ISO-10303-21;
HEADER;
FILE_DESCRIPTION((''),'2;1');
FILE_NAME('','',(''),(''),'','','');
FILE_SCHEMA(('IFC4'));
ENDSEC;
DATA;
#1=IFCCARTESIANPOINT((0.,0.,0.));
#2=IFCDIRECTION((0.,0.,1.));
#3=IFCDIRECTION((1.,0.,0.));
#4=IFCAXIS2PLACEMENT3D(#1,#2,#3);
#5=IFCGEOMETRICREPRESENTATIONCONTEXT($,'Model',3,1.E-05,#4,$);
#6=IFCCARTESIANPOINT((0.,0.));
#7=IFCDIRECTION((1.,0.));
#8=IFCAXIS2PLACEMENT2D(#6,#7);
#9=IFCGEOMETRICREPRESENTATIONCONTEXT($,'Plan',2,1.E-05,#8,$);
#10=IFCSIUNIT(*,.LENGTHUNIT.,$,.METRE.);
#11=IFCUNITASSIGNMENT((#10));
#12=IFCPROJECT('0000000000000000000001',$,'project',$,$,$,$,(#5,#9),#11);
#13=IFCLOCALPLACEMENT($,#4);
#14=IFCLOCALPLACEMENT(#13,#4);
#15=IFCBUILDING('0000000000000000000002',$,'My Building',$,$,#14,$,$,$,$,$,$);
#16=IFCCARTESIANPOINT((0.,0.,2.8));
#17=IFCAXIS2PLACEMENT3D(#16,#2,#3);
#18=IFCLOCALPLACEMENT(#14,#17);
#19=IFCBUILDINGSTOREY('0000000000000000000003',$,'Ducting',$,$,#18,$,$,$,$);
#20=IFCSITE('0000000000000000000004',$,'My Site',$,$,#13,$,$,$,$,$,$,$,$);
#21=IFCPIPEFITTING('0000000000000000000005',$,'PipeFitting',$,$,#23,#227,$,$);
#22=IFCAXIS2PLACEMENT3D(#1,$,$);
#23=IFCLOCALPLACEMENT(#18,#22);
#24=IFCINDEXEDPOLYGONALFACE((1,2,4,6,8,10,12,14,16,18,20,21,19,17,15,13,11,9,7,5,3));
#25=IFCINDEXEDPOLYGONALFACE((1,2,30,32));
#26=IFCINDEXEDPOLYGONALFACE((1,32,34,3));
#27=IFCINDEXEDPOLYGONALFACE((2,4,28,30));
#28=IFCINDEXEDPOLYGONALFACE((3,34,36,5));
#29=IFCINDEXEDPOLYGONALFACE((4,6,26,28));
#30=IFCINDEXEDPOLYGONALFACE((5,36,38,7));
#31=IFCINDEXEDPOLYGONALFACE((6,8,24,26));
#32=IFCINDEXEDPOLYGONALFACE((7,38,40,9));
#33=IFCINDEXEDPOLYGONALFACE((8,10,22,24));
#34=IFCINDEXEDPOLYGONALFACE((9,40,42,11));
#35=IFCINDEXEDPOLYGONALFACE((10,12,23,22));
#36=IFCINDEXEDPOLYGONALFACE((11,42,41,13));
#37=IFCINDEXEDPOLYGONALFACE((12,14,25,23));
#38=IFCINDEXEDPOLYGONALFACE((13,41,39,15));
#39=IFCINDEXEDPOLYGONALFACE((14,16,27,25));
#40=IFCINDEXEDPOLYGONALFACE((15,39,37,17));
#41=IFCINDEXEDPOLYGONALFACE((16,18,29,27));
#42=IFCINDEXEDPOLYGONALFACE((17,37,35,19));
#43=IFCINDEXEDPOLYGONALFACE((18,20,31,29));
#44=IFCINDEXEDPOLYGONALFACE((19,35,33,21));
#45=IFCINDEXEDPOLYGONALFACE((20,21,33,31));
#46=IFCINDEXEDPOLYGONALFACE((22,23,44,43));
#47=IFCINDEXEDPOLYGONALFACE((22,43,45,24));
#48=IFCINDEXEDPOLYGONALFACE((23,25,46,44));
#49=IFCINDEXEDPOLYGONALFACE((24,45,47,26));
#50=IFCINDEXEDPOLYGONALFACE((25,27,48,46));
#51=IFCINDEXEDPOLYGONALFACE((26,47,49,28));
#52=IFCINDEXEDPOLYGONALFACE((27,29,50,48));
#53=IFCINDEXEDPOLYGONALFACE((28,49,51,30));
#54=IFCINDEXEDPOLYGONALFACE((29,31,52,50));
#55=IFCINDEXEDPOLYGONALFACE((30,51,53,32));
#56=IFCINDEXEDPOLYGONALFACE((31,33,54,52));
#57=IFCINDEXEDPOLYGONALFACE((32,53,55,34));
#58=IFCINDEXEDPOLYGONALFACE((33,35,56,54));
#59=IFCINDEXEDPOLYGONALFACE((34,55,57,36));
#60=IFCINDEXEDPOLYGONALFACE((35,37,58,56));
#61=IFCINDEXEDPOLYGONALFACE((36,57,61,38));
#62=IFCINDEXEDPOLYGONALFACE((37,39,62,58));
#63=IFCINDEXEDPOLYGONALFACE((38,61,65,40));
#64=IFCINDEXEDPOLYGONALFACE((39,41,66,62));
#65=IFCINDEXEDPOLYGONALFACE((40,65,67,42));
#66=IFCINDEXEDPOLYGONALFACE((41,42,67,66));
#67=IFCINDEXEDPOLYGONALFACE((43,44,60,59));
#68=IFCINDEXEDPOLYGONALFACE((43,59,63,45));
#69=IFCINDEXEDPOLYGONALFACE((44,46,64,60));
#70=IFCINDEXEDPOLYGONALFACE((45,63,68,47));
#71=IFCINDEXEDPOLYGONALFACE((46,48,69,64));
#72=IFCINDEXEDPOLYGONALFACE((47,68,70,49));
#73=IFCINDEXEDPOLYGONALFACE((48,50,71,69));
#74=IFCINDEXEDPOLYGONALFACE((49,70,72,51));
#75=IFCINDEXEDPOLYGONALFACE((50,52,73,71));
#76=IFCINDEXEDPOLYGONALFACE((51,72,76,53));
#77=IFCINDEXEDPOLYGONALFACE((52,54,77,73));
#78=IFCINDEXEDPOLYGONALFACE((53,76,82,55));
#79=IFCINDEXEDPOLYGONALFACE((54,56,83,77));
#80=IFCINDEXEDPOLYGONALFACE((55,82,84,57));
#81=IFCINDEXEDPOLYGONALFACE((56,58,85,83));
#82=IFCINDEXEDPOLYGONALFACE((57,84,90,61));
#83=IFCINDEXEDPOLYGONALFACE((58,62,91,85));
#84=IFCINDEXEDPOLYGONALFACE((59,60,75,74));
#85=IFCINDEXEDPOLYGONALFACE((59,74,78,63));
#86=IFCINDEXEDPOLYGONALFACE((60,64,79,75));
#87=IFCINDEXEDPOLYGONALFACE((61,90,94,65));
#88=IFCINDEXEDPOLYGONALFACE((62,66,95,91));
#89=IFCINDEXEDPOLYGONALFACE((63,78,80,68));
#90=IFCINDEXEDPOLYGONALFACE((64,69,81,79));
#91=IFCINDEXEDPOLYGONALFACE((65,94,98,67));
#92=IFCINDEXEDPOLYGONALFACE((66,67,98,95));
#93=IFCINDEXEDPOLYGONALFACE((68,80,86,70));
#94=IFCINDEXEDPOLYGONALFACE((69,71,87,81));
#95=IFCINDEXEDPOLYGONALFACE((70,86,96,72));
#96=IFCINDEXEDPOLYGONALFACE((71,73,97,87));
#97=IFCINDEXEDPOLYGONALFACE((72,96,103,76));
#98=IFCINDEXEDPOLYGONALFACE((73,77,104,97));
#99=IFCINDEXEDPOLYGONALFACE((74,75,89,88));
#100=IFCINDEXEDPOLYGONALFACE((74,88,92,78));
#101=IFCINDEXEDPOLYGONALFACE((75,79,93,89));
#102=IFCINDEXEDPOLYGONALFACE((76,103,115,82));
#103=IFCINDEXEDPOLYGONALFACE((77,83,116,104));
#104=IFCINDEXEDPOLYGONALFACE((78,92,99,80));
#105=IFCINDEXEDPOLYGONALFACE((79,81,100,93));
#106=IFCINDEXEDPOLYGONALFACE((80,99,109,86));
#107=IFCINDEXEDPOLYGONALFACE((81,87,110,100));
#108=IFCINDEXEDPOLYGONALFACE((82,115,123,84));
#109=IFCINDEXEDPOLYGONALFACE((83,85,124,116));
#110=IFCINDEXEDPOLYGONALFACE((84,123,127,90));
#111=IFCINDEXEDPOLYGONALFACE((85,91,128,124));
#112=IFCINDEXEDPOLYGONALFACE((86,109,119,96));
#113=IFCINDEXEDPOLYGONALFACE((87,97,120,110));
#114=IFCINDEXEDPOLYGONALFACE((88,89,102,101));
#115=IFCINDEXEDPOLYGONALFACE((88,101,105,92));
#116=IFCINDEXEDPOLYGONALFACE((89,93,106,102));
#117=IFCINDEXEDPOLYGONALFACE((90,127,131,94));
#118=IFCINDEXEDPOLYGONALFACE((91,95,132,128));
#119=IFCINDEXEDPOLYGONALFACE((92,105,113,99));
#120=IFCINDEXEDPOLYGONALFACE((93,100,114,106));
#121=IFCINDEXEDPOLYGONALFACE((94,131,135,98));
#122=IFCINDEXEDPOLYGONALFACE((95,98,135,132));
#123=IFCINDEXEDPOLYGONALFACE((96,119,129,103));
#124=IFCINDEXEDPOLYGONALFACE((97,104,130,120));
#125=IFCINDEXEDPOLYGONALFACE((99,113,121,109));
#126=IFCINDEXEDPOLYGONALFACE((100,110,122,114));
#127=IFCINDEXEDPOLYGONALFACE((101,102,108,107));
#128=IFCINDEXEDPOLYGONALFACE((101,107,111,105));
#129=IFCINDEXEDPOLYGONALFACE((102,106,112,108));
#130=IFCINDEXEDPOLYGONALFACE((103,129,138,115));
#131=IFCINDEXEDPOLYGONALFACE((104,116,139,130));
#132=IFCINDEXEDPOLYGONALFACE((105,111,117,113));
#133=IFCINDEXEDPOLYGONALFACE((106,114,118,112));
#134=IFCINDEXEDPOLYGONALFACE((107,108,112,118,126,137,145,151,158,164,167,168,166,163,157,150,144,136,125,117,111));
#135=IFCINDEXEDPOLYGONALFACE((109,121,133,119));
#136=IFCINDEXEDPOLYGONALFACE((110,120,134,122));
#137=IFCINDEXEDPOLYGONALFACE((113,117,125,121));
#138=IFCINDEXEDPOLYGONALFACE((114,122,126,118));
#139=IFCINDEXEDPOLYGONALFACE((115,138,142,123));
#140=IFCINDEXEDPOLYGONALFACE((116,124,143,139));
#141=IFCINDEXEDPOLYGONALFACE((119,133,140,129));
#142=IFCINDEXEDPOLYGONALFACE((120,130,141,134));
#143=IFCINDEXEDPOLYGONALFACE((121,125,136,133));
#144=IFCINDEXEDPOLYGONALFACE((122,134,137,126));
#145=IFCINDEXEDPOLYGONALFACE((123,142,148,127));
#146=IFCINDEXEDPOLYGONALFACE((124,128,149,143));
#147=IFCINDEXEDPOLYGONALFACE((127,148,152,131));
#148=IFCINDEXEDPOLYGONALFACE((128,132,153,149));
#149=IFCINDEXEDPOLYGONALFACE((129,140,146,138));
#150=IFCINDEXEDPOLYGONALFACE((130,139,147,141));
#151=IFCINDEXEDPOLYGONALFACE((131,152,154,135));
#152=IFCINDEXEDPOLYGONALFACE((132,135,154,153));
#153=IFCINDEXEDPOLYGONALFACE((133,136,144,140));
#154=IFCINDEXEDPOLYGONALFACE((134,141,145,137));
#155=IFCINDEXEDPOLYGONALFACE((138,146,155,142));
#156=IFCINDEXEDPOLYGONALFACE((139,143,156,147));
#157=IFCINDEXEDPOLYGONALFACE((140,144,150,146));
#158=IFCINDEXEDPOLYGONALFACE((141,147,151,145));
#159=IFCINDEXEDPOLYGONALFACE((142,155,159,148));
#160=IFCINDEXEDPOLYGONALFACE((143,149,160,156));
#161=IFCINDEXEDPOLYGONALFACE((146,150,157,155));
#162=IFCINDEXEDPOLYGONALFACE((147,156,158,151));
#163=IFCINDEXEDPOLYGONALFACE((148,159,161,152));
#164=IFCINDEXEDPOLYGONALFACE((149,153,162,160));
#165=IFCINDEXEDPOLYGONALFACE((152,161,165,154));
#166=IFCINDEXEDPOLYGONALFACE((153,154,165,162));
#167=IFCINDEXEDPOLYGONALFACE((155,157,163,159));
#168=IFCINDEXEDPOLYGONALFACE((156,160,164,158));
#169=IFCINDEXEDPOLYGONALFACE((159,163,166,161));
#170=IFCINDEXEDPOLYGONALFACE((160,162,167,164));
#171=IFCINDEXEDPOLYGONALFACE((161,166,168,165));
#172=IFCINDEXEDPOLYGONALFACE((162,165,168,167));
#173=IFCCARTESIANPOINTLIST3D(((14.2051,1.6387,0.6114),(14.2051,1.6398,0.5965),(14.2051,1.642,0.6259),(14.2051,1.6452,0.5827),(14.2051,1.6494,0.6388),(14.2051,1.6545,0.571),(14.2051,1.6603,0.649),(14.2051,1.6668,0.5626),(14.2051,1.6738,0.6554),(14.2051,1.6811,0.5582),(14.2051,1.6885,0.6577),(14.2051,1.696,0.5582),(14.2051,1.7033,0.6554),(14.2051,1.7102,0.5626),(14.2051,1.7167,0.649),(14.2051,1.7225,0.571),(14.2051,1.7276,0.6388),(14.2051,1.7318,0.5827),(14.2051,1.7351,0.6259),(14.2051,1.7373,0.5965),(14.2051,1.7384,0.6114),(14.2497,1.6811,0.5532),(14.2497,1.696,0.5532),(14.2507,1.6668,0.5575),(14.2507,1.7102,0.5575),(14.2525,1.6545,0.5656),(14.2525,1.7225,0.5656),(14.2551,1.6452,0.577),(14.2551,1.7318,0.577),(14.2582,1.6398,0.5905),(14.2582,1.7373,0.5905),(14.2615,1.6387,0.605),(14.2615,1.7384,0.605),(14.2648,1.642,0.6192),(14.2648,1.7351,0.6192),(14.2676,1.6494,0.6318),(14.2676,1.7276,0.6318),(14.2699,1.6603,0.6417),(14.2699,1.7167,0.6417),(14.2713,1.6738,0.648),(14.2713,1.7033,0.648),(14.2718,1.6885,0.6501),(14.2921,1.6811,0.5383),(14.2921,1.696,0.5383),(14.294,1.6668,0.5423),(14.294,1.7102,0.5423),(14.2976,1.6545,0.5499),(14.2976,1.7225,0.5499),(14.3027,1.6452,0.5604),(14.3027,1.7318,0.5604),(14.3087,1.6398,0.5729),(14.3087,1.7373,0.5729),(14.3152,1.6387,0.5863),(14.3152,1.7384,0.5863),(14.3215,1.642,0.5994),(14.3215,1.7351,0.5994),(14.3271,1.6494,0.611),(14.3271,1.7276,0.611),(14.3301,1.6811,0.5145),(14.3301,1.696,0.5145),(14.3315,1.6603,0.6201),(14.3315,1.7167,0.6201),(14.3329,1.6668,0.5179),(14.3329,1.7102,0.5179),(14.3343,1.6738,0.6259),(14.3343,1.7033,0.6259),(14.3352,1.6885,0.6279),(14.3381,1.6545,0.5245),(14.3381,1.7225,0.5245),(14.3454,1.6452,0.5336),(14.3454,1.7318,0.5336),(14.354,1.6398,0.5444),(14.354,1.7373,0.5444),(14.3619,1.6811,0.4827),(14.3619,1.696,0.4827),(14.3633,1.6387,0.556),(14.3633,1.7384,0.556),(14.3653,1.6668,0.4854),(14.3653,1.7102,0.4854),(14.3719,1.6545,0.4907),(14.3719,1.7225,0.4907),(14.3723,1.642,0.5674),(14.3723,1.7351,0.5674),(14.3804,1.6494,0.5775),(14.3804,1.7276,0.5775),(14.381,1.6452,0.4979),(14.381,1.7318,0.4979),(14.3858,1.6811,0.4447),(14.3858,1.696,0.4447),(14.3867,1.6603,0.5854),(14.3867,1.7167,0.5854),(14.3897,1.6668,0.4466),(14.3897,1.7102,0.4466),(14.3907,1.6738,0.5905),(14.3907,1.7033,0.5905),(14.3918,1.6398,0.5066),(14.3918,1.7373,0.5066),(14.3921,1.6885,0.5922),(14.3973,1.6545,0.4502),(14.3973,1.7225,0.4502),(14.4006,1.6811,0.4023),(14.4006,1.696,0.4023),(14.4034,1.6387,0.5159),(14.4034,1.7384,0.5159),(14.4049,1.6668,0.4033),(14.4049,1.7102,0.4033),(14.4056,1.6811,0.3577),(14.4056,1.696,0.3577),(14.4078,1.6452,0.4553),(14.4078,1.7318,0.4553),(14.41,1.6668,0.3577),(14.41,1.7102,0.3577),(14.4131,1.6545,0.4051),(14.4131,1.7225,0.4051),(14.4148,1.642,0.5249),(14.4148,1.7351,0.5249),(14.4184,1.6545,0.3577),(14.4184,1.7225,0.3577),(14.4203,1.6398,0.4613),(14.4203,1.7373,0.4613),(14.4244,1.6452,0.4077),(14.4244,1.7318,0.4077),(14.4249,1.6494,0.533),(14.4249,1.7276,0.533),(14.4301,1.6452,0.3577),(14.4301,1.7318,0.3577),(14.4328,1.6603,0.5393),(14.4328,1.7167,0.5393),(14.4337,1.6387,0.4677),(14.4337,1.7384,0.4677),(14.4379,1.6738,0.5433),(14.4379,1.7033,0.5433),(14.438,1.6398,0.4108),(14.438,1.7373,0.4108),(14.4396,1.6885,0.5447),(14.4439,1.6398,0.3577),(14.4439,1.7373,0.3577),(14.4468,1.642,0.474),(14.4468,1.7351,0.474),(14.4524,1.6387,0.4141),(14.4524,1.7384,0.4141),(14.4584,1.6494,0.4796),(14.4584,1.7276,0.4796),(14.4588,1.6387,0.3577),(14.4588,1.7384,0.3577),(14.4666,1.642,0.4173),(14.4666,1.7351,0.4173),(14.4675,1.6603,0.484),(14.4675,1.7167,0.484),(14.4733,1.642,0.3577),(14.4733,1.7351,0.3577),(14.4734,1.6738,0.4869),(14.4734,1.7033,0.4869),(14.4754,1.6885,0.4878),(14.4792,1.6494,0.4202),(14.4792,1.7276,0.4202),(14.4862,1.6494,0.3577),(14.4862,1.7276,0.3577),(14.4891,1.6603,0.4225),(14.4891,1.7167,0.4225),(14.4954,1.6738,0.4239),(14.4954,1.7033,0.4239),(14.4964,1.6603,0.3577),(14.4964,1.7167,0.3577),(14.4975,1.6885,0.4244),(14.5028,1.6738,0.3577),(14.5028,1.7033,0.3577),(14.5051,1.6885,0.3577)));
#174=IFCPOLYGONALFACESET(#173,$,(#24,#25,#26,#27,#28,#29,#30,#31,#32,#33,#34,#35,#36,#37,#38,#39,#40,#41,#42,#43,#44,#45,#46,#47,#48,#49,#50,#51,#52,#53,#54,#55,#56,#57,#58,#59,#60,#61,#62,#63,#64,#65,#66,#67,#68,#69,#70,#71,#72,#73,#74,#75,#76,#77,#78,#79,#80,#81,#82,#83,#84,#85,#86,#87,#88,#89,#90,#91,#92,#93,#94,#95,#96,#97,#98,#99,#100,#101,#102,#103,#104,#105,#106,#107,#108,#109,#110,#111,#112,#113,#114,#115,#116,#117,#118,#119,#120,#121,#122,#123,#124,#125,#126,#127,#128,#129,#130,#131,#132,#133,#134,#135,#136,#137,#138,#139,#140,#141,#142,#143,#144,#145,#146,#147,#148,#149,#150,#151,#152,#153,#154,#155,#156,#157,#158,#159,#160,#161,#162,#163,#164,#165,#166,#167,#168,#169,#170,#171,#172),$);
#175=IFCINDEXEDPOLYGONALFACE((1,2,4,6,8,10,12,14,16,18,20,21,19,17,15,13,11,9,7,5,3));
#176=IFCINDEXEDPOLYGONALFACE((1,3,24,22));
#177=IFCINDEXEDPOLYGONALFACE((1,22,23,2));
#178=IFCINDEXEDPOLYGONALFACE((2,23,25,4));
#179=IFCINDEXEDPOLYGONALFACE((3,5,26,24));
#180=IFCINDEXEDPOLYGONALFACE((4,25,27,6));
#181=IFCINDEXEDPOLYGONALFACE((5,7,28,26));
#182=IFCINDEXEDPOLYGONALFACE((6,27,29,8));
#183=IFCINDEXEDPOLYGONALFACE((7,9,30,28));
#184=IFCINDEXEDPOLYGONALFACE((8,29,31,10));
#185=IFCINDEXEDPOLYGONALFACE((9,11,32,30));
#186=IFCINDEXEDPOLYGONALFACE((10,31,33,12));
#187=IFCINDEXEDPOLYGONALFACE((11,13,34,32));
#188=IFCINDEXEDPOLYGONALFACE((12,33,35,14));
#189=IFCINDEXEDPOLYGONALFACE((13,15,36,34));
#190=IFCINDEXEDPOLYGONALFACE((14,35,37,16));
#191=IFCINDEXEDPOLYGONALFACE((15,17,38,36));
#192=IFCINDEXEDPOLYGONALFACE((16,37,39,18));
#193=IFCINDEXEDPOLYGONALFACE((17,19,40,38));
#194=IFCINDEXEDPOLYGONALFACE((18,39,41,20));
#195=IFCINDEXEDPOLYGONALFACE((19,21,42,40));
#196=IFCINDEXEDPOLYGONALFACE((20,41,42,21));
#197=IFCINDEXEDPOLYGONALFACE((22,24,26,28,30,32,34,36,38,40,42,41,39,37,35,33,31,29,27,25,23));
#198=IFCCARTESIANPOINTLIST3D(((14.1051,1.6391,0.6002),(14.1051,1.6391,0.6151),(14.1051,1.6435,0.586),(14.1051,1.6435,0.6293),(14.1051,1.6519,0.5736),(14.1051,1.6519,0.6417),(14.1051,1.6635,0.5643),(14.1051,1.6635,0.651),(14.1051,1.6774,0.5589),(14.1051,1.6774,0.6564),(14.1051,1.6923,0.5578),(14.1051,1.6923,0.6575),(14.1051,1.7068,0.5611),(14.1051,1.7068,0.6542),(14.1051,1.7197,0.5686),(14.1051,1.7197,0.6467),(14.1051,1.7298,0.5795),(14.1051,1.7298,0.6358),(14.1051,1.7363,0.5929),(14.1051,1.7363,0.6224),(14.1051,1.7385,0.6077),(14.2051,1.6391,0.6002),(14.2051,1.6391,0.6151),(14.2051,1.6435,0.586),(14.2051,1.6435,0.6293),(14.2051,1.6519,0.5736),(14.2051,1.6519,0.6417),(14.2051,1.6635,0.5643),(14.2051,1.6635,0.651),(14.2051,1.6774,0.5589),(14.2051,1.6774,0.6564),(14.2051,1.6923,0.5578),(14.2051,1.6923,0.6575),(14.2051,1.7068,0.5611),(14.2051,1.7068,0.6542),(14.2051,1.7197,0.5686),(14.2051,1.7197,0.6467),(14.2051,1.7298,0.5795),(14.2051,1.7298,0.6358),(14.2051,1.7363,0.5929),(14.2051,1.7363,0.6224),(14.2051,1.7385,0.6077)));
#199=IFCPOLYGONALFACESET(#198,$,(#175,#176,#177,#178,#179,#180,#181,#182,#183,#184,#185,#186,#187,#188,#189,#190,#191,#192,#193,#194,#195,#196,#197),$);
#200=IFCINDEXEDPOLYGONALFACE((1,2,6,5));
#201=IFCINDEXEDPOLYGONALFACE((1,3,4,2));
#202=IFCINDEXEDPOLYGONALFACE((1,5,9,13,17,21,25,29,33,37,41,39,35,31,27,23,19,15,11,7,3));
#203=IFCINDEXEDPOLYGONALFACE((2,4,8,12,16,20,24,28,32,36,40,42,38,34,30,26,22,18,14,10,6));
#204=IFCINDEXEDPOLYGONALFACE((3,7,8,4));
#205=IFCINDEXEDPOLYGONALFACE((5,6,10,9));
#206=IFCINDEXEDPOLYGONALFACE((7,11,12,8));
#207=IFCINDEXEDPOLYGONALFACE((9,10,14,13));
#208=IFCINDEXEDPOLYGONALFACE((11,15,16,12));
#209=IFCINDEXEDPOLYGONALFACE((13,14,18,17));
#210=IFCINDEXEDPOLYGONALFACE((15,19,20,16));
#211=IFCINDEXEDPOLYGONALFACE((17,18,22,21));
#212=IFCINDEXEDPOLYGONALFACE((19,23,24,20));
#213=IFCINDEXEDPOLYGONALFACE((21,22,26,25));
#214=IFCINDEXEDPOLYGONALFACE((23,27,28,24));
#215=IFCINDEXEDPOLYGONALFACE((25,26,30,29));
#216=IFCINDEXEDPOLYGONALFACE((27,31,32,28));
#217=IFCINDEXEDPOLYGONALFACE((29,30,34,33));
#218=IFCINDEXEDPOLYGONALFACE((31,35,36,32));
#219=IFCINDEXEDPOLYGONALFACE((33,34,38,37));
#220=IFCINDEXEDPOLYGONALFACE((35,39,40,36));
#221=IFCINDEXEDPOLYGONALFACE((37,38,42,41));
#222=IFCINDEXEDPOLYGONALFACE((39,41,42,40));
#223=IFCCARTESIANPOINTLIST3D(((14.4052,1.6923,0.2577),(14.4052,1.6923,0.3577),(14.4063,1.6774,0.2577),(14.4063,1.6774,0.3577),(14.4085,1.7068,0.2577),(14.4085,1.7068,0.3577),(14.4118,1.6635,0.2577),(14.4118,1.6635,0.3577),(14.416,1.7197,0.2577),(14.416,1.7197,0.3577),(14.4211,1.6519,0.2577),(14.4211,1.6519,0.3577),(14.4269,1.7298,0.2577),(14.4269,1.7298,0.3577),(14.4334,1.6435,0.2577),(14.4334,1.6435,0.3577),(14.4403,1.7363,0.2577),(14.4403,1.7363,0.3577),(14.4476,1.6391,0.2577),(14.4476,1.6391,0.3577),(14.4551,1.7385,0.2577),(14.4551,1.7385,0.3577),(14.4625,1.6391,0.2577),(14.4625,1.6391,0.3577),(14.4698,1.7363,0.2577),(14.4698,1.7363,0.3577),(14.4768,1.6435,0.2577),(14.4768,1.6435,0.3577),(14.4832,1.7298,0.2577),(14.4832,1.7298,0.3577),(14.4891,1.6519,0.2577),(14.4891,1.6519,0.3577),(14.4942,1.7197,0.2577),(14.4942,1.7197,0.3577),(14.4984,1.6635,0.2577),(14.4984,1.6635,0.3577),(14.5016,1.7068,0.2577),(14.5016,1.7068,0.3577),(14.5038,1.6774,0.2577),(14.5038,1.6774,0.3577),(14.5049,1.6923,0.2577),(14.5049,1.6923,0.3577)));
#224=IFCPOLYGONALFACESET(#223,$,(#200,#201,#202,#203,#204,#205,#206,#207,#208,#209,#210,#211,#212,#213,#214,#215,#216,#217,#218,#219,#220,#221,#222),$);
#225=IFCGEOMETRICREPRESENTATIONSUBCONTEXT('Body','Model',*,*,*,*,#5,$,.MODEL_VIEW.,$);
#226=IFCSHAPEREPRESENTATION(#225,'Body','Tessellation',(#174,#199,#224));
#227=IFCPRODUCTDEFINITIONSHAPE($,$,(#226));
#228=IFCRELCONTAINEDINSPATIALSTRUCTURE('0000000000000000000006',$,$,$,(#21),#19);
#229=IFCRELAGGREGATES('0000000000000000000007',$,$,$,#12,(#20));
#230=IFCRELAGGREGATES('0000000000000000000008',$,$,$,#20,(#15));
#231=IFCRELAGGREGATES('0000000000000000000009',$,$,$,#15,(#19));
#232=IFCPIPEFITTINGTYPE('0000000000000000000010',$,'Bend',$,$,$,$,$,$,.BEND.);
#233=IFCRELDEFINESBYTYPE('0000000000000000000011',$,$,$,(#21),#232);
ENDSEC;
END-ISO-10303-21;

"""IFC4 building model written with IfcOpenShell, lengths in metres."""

from ifc_helpers import new_model, entity, si_unit, frame, origin_with_axes, origin_2d_with_axis, place, context, subcontext, project, spatial, circle, extrude, source, transform, mapped, type_object, type_shapes, element, save


model = new_model("IFC4")

# Units and contexts
model_context = context("Model", 3, precision=1e-05, world=origin_with_axes())
plan_context = context("Plan", 2, precision=1e-05, world=origin_2d_with_axis())
body_context = subcontext(model_context, "Body", "Model", "MODEL_VIEW")
ifc_project = project(units=[si_unit("LENGTHUNIT", "METRE")], contexts=[model_context, plan_context])

# Site, building, storey
site_placement = place(None, origin_with_axes())
site = spatial("IfcSite", under=ifc_project, at=site_placement, Name="My Site")
building_placement = place(site_placement, origin_with_axes())
building = spatial("IfcBuilding", under=site, at=building_placement, Name="My Building")
storey_placement = place(building_placement, frame((0.0, 0.0, 2.8), z_axis=(0.0, 0.0, 1.0), x_axis=(1.0, 0.0, 0.0)))
storey = spatial("IfcBuildingStorey", under=building, at=storey_placement, Name="Ducting")

# Pipe fitting
pipe_fitting_type = type_object("IfcPipeFittingType", Name="Bend", PredefinedType="BEND")
shared_shape_1 = source(origin_with_axes(), body_context, "Body", "SolidModel", [
    entity("IfcSweptDiskSolid", entity("IfcIndexedPolyCurve", entity("IfcCartesianPointList3D", [[0.0, 0.0, 0.1], [0.0, -0.0732, 0.2768], [0.0, -0.25, 0.35]]), [entity("IfcArcIndex", [1, 2, 3])]), 0.05),
    extrude(circle(Radius=0.05), origin_with_axes(), (0.0, 0.0, 1.0), 0.1),
    extrude(circle(Radius=0.05), frame((0.0, -0.25, 0.35), z_axis=(0.0, -1.0, 0.0), x_axis=(1.0, 0.0, 0.0)), (0.0, 0.0, 1.0), 0.1),
])
type_shapes(pipe_fitting_type, [shared_shape_1])
for number, where, z_axis, x_axis, name in (
    (1, (14.1051, 1.6885, 0.6077), (1.0, 0.0, 0.0), (0.0, 1.0, 0.0), "PipeFitting"),
):
    element("IfcPipeFitting", number, at=place(storey_placement, frame(where, z_axis=z_axis, x_axis=x_axis)), inside=storey, type_object=pipe_fitting_type, Name=name, context=body_context, shape_type="MappedRepresentation", body=[
        mapped(shared_shape_1, transform((0.0, 0.0, 0.0), x_axis=(1.0, 0.0, 0.0), y_axis=(0.0, 1.0, 0.0), z_axis=(0.0, 0.0, 1.0), scale=1.0)),
    ])

save(model, "model.ifc")
